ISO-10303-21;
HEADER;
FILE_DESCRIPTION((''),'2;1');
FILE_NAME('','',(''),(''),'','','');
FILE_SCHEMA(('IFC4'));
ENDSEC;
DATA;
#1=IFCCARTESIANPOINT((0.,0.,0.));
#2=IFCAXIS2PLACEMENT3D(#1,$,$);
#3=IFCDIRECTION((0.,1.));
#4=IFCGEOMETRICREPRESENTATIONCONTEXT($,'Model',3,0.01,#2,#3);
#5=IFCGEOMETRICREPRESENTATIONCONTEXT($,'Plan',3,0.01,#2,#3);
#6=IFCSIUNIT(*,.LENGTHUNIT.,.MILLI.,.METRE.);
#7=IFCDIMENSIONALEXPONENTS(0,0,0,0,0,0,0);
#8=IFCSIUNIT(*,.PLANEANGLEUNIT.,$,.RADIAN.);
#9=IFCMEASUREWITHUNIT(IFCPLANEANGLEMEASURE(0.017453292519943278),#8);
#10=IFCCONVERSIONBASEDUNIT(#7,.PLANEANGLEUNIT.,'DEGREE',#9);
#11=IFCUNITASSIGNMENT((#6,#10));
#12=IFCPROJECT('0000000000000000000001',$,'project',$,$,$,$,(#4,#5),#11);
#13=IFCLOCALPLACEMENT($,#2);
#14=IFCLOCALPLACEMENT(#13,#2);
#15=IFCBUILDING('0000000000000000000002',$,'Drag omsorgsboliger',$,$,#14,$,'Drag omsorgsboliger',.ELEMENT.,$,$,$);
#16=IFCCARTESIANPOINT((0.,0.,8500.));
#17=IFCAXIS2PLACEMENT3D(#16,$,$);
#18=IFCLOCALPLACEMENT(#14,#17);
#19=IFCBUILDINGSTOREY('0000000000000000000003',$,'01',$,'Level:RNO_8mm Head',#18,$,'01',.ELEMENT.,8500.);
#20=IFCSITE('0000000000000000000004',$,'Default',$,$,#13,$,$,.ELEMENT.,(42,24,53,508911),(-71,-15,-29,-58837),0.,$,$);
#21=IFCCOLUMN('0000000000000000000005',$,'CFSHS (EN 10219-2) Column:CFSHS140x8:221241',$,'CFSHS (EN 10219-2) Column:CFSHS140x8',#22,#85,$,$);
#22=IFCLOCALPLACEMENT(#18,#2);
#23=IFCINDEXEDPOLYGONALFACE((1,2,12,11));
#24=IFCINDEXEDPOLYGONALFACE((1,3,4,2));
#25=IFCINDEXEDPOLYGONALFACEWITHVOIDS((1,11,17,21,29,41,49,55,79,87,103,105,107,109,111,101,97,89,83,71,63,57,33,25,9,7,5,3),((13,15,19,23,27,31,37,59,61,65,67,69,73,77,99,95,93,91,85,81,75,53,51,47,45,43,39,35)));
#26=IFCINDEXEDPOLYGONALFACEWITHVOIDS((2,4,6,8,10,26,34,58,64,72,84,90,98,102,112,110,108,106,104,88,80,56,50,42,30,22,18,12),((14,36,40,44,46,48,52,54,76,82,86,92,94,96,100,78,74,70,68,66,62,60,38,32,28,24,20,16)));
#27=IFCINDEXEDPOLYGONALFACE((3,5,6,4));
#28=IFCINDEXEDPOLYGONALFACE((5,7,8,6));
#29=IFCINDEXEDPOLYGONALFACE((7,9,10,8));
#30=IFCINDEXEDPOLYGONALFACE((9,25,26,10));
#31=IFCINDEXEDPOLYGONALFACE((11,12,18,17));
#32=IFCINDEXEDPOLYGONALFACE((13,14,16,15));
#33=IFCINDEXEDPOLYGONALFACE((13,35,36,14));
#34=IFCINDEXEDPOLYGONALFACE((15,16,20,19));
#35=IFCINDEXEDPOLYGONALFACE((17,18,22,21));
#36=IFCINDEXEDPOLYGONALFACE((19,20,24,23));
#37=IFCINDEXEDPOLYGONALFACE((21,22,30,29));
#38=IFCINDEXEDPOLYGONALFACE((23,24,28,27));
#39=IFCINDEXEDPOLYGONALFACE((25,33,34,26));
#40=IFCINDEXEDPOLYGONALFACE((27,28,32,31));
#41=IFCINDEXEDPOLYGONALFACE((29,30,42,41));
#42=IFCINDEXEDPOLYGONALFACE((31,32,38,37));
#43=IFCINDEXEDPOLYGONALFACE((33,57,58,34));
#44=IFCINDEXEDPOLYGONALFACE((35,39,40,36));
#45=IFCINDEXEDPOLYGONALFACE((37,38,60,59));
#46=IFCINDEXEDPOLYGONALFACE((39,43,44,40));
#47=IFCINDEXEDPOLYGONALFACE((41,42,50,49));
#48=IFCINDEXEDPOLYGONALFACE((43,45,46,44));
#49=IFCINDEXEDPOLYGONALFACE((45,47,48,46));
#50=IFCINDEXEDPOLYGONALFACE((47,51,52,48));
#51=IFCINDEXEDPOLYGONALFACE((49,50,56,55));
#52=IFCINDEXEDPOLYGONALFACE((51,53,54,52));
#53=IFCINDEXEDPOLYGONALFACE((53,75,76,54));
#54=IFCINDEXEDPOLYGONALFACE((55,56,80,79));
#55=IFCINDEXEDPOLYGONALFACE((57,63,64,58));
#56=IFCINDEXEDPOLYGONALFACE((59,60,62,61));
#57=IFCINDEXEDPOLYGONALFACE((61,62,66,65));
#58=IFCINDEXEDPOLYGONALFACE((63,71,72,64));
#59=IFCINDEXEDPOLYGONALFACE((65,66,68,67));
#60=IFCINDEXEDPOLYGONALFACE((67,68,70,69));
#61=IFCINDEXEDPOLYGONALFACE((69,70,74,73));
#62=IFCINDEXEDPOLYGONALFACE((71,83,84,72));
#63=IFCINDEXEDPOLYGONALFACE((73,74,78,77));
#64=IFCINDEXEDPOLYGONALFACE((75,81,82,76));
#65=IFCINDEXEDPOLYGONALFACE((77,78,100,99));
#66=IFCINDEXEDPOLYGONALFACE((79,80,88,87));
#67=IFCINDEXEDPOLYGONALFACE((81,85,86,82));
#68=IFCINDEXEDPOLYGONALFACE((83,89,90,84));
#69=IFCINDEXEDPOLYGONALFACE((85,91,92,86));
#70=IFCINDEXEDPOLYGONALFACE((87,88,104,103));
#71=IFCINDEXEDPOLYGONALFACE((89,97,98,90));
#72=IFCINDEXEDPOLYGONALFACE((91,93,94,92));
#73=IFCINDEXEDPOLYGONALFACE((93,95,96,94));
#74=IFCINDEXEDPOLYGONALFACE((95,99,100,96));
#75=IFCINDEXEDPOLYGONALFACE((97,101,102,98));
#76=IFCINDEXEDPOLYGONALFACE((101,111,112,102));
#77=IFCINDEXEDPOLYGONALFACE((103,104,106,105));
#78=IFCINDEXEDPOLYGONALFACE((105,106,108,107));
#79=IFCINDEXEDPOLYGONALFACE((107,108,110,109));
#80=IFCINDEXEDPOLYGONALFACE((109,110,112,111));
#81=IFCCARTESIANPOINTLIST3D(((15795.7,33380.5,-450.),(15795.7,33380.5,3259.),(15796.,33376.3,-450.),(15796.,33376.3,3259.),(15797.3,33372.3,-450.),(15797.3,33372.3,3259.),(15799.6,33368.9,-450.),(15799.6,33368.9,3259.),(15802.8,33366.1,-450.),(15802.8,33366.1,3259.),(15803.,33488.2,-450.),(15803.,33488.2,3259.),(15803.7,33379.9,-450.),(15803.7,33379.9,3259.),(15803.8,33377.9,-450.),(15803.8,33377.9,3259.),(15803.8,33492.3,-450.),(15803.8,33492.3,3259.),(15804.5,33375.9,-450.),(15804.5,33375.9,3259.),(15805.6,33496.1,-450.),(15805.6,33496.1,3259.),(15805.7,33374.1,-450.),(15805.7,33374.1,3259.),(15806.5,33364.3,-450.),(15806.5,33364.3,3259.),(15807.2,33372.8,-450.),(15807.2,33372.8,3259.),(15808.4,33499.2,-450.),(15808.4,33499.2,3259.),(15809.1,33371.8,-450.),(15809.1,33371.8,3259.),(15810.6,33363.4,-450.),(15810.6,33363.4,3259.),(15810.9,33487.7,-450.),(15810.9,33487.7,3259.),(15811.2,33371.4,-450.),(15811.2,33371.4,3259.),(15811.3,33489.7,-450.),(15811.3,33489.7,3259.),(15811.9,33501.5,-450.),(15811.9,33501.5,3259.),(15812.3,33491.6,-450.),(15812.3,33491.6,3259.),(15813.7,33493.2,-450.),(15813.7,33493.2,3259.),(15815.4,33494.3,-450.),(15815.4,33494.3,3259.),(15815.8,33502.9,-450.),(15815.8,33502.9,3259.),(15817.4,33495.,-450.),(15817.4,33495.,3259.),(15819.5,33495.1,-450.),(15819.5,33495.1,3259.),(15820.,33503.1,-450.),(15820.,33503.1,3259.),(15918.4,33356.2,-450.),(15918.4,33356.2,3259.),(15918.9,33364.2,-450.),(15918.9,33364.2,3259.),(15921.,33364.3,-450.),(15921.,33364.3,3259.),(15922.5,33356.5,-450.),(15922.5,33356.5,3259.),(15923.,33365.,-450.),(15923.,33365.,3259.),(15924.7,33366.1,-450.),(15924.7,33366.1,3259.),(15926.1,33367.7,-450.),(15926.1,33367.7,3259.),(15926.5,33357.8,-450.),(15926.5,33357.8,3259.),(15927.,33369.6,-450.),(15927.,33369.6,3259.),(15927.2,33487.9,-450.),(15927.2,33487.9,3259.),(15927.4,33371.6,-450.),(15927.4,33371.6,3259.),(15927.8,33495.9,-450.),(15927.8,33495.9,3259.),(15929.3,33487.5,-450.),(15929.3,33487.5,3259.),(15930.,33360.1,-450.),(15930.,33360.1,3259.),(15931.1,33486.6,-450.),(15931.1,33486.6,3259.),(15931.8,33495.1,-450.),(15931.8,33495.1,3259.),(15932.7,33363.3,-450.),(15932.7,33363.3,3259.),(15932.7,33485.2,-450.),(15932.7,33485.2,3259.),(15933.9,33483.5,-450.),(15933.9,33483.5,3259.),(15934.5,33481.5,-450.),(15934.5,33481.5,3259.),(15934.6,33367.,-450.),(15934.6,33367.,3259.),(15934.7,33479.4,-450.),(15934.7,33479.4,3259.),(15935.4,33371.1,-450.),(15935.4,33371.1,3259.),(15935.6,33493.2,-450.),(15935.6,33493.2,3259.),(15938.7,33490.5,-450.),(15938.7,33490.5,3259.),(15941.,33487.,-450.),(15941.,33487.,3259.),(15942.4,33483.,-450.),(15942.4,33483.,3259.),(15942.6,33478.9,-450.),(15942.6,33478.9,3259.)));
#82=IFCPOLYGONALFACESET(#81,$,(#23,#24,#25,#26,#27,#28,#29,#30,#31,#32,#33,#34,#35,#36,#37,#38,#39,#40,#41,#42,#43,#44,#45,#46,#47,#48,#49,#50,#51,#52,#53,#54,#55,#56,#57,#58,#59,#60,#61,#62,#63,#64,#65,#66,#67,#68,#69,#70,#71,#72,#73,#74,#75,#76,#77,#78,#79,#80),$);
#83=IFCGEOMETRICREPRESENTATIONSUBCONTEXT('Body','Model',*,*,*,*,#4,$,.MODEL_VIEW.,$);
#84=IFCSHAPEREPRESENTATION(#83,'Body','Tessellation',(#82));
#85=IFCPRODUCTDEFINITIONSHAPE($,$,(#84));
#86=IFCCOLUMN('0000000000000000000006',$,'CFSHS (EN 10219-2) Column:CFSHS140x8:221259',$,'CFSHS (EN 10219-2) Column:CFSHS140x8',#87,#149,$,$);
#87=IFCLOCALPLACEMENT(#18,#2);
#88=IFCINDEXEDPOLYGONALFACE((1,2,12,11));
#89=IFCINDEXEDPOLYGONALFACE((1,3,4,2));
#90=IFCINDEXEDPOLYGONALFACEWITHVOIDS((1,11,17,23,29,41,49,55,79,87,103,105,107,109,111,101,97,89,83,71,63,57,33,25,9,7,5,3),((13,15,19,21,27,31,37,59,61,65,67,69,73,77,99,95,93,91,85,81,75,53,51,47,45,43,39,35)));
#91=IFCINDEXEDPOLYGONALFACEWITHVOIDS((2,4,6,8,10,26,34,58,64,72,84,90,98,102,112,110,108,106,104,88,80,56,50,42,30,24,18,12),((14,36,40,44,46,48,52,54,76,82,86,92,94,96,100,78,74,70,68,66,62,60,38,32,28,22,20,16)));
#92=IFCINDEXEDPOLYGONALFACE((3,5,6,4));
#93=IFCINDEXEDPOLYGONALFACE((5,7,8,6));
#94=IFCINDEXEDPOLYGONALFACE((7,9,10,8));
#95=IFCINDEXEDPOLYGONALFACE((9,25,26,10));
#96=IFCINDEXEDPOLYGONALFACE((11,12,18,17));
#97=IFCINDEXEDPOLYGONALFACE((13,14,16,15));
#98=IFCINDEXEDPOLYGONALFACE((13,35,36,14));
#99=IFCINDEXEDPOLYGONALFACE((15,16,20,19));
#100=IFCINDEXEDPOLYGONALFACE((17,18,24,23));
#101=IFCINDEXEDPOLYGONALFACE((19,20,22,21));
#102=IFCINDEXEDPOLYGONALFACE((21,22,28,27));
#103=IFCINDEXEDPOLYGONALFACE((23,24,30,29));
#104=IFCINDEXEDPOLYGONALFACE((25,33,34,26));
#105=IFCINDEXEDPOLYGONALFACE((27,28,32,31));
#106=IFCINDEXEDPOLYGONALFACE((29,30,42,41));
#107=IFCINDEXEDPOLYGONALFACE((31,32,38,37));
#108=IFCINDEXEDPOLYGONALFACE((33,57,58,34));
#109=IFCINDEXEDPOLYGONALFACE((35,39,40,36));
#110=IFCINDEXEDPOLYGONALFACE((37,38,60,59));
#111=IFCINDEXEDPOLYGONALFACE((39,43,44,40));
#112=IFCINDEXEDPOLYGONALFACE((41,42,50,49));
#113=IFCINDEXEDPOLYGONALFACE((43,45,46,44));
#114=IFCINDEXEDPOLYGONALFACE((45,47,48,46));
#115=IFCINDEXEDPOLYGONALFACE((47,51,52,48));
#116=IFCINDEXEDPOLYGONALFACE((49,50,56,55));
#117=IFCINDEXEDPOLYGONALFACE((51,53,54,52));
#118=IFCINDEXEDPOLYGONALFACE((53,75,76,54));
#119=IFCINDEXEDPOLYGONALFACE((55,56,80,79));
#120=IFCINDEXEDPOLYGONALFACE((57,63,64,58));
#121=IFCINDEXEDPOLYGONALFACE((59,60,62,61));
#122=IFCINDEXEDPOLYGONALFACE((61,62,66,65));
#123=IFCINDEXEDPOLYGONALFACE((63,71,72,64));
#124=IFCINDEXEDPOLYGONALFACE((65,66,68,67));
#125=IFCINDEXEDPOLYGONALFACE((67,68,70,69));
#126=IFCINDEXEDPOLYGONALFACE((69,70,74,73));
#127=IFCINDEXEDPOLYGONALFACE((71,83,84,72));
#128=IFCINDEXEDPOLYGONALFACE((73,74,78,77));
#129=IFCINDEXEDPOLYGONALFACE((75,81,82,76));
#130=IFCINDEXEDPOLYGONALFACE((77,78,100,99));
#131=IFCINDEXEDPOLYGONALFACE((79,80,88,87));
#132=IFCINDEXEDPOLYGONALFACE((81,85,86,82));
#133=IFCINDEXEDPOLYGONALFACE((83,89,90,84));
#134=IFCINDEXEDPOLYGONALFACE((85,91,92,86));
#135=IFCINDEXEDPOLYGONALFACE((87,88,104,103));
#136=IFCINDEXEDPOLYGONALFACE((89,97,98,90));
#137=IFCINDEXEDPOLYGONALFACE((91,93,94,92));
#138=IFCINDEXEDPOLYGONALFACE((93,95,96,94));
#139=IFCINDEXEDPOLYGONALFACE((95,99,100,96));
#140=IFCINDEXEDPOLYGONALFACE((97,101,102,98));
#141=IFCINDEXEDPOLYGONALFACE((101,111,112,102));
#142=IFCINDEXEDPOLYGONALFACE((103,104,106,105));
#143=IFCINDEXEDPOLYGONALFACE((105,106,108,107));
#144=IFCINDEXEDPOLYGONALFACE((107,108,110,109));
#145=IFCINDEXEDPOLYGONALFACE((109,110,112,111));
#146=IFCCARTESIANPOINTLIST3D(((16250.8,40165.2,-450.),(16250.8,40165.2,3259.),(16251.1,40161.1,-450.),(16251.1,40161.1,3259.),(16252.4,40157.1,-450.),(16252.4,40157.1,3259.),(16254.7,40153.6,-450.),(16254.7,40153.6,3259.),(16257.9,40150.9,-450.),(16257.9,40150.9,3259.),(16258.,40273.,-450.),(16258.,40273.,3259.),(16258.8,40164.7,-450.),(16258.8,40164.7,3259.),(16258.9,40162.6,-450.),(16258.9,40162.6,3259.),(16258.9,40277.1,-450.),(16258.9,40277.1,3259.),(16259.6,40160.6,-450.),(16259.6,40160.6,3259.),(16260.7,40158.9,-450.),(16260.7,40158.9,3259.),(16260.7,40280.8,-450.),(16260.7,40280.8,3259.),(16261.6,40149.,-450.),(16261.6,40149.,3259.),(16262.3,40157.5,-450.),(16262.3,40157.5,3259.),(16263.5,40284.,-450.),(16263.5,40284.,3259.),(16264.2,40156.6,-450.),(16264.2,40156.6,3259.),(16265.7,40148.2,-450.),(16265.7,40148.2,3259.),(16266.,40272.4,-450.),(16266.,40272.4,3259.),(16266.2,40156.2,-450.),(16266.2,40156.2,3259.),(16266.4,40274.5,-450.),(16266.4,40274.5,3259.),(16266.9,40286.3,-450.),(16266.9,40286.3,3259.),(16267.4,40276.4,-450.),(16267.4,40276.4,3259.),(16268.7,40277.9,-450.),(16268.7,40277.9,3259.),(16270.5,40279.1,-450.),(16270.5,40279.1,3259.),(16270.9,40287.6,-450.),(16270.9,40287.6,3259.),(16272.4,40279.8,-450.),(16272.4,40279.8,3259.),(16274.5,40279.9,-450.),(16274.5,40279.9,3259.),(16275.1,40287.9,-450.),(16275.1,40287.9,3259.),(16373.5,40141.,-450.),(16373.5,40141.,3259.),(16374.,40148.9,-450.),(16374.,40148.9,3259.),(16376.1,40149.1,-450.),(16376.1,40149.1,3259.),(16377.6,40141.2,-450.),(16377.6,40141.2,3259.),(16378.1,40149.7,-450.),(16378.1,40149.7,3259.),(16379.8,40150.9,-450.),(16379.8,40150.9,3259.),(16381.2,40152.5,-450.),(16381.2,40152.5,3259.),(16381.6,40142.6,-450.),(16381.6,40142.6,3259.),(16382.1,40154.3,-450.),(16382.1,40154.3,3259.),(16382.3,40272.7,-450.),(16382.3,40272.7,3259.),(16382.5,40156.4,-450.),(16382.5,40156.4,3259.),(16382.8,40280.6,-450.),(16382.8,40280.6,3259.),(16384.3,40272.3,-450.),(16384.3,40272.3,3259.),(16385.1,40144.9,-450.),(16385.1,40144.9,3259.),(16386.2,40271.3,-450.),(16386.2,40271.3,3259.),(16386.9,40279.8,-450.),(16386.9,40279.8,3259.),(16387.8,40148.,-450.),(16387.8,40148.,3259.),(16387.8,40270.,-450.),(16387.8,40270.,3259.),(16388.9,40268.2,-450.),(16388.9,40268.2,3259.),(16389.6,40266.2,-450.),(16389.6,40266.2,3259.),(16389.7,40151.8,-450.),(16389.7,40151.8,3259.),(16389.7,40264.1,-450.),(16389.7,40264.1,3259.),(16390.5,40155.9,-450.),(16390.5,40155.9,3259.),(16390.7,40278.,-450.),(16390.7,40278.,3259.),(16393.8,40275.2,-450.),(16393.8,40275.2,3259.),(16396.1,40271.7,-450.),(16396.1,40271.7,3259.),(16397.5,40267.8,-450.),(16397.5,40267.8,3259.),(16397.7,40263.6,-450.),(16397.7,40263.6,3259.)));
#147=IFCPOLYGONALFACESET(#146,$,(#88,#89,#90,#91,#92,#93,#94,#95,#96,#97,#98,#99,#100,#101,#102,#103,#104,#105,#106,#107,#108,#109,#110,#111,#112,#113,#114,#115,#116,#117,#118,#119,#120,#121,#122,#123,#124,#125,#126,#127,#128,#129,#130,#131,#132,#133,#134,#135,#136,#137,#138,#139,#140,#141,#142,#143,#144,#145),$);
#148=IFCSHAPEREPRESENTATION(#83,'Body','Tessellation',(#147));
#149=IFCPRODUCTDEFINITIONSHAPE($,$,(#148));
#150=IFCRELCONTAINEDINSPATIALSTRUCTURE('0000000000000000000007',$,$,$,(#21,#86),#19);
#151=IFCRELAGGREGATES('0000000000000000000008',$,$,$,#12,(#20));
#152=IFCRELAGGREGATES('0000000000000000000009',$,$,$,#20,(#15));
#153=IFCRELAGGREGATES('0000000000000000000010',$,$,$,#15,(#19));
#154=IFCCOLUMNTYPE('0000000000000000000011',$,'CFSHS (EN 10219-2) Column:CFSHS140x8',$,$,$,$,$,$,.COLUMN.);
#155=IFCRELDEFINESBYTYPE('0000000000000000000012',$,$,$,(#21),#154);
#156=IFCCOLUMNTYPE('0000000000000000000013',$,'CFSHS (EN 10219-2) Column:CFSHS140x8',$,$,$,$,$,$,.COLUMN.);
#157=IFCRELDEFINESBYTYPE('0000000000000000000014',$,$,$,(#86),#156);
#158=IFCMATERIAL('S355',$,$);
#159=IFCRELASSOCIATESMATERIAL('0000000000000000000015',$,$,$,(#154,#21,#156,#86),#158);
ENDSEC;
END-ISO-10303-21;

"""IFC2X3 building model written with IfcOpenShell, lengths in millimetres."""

from ifc_helpers import new_model, entity, si_unit, converted_unit, direction, frame, frame_2d, origin, place, context, subcontext, project, spatial, polyline, circle_curve, parameter, trimmed, segment, composite_curve, outline, extrude, source, transform, mapped, material, type_object, type_shapes, element, save


model = new_model("IFC2X3")

# Units and contexts
model_context = context("Model", 3, precision=0.01, world=origin(), true_north=direction((0.0, 1.0)))
plan_context = context("Plan", 3, precision=0.01, world=origin(), true_north=direction((0.0, 1.0)))
body_context = subcontext(model_context, "Body", "Model", "MODEL_VIEW")
ifc_project = project(units=[si_unit("LENGTHUNIT", "METRE", prefix="MILLI"), converted_unit("PLANEANGLEUNIT", "DEGREE", entity("IfcPlaneAngleMeasure", 0.017453292519943278), si_unit("PLANEANGLEUNIT", "RADIAN"), dimensions=[0, 0, 0, 0, 0, 0, 0])], contexts=[model_context, plan_context])

# Site, building, storey
site_placement = place(None, origin())
site = spatial("IfcSite", under=ifc_project, at=site_placement, Name="Default", CompositionType="ELEMENT", RefLatitude=(42, 24, 53, 508911), RefLongitude=(-71, -15, -29, -58837), RefElevation=0.0)
building_placement = place(site_placement, origin())
building = spatial("IfcBuilding", under=site, at=building_placement, Name="Drag omsorgsboliger", LongName="Drag omsorgsboliger", CompositionType="ELEMENT")
storey_placement = place(building_placement, frame((0.0, 0.0, 8500.0)))
storey = spatial("IfcBuildingStorey", under=building, at=storey_placement, Name="01", ObjectType="Level:RNO_8mm Head", LongName="01", CompositionType="ELEMENT", Elevation=8500.0)

# Columns
ifc_material = material(Name="S355")
column_type_1 = type_object("IfcColumnType", Name="CFSHS (EN 10219-2) Column:CFSHS140x8", PredefinedType="COLUMN", material=ifc_material)
shared_shape_1 = source(origin(), body_context, "Body", "SweptSolid", [
    extrude(outline(composite_curve([segment(polyline([(-54.0, -70.0), (54.0, -70.0)]), True, "CONTINUOUS"), segment(trimmed(circle_curve(frame_2d((54.0, -54.0), x_axis=(-1.0, 0.0)), 16.0), [parameter(90.0)], [parameter(180.0)], True, "PARAMETER"), True, "CONTINUOUS"), segment(polyline([(70.0, -54.0), (70.0, 54.0)]), True, "CONTINUOUS"), segment(trimmed(circle_curve(frame_2d((54.0, 54.0), x_axis=(-1.0, 0.0)), 16.0), [parameter(180.0)], [parameter(270.0)], True, "PARAMETER"), True, "CONTINUOUS"), segment(polyline([(54.0, 70.0), (-54.0, 70.0)]), True, "CONTINUOUS"), segment(trimmed(circle_curve(frame_2d((-54.0, 54.0), x_axis=(-1.0, 0.0)), 16.0), [parameter(270.0)], [parameter(360.0)], True, "PARAMETER"), True, "CONTINUOUS"), segment(polyline([(-70.0, 54.0), (-70.0, -54.0)]), True, "CONTINUOUS"), segment(trimmed(circle_curve(frame_2d((-54.0, -54.0), x_axis=(-1.0, 0.0)), 16.0), [parameter(360.0)], [parameter(90.0)], True, "PARAMETER"), True, "CONTINUOUS")], self_intersect=False), holes=[composite_curve([segment(trimmed(circle_curve(frame_2d((-54.0, -54.0), x_axis=(-1.0, 0.0)), 8.0), [parameter(360.0)], [parameter(90.0)], True, "PARAMETER"), False, "CONTINUOUS"), segment(polyline([(-62.0, -54.0), (-62.0, 54.0)]), True, "CONTINUOUS"), segment(trimmed(circle_curve(frame_2d((-54.0, 54.0), x_axis=(-1.0, 0.0)), 8.0), [parameter(270.0)], [parameter(360.0)], True, "PARAMETER"), False, "CONTINUOUS"), segment(polyline([(-54.0, 62.0), (54.0, 62.0)]), True, "CONTINUOUS"), segment(trimmed(circle_curve(frame_2d((54.0, 54.0), x_axis=(-1.0, 0.0)), 8.0), [parameter(180.0)], [parameter(270.0)], True, "PARAMETER"), False, "CONTINUOUS"), segment(polyline([(62.0, 54.0), (62.0, -54.0)]), True, "CONTINUOUS"), segment(trimmed(circle_curve(frame_2d((54.0, -54.0), x_axis=(-1.0, 0.0)), 8.0), [parameter(90.0)], [parameter(180.0)], True, "PARAMETER"), False, "CONTINUOUS"), segment(polyline([(54.0, -62.0), (-54.0, -62.0)]), True, "CONTINUOUS")], self_intersect=False)]), frame((15869.2, 33429.7, 8050.0), z_axis=(0.0, 0.0, 1.0), x_axis=(-0.997758, 0.066923, 0.0)), (0.0, 0.0, 1.0), 3709.0),
])
type_shapes(column_type_1, [shared_shape_1])
column_1_placement = place(storey_placement, frame((0.0, 0.0, -8500.0)))
element("IfcColumn", 1, at=column_1_placement, inside=storey, type_object=column_type_1, material=ifc_material, Name="CFSHS (EN 10219-2) Column:CFSHS140x8:221241", ObjectType="CFSHS (EN 10219-2) Column:CFSHS140x8", context=body_context, shape_type="MappedRepresentation", body=[
    mapped(shared_shape_1, transform((0.0, 0.0, 0.0), scale=1.0)),
])
column_type_2 = type_object("IfcColumnType", Name="CFSHS (EN 10219-2) Column:CFSHS140x8", PredefinedType="COLUMN", material=ifc_material)
shared_shape_2 = source(origin(), body_context, "Body", "SweptSolid", [
    extrude(outline(composite_curve([segment(polyline([(-54.0, -70.0), (54.0, -70.0)]), True, "CONTINUOUS"), segment(trimmed(circle_curve(frame_2d((54.0, -54.0), x_axis=(-1.0, 0.0)), 16.0), [parameter(90.0)], [parameter(180.0)], True, "PARAMETER"), True, "CONTINUOUS"), segment(polyline([(70.0, -54.0), (70.0, 54.0)]), True, "CONTINUOUS"), segment(trimmed(circle_curve(frame_2d((54.0, 54.0), x_axis=(-1.0, 0.0)), 16.0), [parameter(180.0)], [parameter(270.0)], True, "PARAMETER"), True, "CONTINUOUS"), segment(polyline([(54.0, 70.0), (-54.0, 70.0)]), True, "CONTINUOUS"), segment(trimmed(circle_curve(frame_2d((-54.0, 54.0), x_axis=(-1.0, 0.0)), 16.0), [parameter(270.0)], [parameter(360.0)], True, "PARAMETER"), True, "CONTINUOUS"), segment(polyline([(-70.0, 54.0), (-70.0, -54.0)]), True, "CONTINUOUS"), segment(trimmed(circle_curve(frame_2d((-54.0, -54.0), x_axis=(-1.0, 0.0)), 16.0), [parameter(360.0)], [parameter(90.0)], True, "PARAMETER"), True, "CONTINUOUS")], self_intersect=False), holes=[composite_curve([segment(trimmed(circle_curve(frame_2d((-54.0, -54.0), x_axis=(-1.0, 0.0)), 8.0), [parameter(360.0)], [parameter(90.0)], True, "PARAMETER"), False, "CONTINUOUS"), segment(polyline([(-62.0, -54.0), (-62.0, 54.0)]), True, "CONTINUOUS"), segment(trimmed(circle_curve(frame_2d((-54.0, 54.0), x_axis=(-1.0, 0.0)), 8.0), [parameter(270.0)], [parameter(360.0)], True, "PARAMETER"), False, "CONTINUOUS"), segment(polyline([(-54.0, 62.0), (54.0, 62.0)]), True, "CONTINUOUS"), segment(trimmed(circle_curve(frame_2d((54.0, 54.0), x_axis=(-1.0, 0.0)), 8.0), [parameter(180.0)], [parameter(270.0)], True, "PARAMETER"), False, "CONTINUOUS"), segment(polyline([(62.0, 54.0), (62.0, -54.0)]), True, "CONTINUOUS"), segment(trimmed(circle_curve(frame_2d((54.0, -54.0), x_axis=(-1.0, 0.0)), 8.0), [parameter(90.0)], [parameter(180.0)], True, "PARAMETER"), False, "CONTINUOUS"), segment(polyline([(54.0, -62.0), (-54.0, -62.0)]), True, "CONTINUOUS")], self_intersect=False)]), frame((16324.3, 40214.4, 8050.0), z_axis=(0.0, 0.0, 1.0), x_axis=(-0.997758, 0.066923, 0.0)), (0.0, 0.0, 1.0), 3709.0),
])
type_shapes(column_type_2, [shared_shape_2])
column_2_placement = place(storey_placement, frame((0.0, 0.0, -8500.0)))
element("IfcColumn", 2, at=column_2_placement, inside=storey, type_object=column_type_2, material=ifc_material, Name="CFSHS (EN 10219-2) Column:CFSHS140x8:221259", ObjectType="CFSHS (EN 10219-2) Column:CFSHS140x8", context=body_context, shape_type="MappedRepresentation", body=[
    mapped(shared_shape_2, transform((0.0, 0.0, 0.0), scale=1.0)),
])

save(model, "model.ifc")
